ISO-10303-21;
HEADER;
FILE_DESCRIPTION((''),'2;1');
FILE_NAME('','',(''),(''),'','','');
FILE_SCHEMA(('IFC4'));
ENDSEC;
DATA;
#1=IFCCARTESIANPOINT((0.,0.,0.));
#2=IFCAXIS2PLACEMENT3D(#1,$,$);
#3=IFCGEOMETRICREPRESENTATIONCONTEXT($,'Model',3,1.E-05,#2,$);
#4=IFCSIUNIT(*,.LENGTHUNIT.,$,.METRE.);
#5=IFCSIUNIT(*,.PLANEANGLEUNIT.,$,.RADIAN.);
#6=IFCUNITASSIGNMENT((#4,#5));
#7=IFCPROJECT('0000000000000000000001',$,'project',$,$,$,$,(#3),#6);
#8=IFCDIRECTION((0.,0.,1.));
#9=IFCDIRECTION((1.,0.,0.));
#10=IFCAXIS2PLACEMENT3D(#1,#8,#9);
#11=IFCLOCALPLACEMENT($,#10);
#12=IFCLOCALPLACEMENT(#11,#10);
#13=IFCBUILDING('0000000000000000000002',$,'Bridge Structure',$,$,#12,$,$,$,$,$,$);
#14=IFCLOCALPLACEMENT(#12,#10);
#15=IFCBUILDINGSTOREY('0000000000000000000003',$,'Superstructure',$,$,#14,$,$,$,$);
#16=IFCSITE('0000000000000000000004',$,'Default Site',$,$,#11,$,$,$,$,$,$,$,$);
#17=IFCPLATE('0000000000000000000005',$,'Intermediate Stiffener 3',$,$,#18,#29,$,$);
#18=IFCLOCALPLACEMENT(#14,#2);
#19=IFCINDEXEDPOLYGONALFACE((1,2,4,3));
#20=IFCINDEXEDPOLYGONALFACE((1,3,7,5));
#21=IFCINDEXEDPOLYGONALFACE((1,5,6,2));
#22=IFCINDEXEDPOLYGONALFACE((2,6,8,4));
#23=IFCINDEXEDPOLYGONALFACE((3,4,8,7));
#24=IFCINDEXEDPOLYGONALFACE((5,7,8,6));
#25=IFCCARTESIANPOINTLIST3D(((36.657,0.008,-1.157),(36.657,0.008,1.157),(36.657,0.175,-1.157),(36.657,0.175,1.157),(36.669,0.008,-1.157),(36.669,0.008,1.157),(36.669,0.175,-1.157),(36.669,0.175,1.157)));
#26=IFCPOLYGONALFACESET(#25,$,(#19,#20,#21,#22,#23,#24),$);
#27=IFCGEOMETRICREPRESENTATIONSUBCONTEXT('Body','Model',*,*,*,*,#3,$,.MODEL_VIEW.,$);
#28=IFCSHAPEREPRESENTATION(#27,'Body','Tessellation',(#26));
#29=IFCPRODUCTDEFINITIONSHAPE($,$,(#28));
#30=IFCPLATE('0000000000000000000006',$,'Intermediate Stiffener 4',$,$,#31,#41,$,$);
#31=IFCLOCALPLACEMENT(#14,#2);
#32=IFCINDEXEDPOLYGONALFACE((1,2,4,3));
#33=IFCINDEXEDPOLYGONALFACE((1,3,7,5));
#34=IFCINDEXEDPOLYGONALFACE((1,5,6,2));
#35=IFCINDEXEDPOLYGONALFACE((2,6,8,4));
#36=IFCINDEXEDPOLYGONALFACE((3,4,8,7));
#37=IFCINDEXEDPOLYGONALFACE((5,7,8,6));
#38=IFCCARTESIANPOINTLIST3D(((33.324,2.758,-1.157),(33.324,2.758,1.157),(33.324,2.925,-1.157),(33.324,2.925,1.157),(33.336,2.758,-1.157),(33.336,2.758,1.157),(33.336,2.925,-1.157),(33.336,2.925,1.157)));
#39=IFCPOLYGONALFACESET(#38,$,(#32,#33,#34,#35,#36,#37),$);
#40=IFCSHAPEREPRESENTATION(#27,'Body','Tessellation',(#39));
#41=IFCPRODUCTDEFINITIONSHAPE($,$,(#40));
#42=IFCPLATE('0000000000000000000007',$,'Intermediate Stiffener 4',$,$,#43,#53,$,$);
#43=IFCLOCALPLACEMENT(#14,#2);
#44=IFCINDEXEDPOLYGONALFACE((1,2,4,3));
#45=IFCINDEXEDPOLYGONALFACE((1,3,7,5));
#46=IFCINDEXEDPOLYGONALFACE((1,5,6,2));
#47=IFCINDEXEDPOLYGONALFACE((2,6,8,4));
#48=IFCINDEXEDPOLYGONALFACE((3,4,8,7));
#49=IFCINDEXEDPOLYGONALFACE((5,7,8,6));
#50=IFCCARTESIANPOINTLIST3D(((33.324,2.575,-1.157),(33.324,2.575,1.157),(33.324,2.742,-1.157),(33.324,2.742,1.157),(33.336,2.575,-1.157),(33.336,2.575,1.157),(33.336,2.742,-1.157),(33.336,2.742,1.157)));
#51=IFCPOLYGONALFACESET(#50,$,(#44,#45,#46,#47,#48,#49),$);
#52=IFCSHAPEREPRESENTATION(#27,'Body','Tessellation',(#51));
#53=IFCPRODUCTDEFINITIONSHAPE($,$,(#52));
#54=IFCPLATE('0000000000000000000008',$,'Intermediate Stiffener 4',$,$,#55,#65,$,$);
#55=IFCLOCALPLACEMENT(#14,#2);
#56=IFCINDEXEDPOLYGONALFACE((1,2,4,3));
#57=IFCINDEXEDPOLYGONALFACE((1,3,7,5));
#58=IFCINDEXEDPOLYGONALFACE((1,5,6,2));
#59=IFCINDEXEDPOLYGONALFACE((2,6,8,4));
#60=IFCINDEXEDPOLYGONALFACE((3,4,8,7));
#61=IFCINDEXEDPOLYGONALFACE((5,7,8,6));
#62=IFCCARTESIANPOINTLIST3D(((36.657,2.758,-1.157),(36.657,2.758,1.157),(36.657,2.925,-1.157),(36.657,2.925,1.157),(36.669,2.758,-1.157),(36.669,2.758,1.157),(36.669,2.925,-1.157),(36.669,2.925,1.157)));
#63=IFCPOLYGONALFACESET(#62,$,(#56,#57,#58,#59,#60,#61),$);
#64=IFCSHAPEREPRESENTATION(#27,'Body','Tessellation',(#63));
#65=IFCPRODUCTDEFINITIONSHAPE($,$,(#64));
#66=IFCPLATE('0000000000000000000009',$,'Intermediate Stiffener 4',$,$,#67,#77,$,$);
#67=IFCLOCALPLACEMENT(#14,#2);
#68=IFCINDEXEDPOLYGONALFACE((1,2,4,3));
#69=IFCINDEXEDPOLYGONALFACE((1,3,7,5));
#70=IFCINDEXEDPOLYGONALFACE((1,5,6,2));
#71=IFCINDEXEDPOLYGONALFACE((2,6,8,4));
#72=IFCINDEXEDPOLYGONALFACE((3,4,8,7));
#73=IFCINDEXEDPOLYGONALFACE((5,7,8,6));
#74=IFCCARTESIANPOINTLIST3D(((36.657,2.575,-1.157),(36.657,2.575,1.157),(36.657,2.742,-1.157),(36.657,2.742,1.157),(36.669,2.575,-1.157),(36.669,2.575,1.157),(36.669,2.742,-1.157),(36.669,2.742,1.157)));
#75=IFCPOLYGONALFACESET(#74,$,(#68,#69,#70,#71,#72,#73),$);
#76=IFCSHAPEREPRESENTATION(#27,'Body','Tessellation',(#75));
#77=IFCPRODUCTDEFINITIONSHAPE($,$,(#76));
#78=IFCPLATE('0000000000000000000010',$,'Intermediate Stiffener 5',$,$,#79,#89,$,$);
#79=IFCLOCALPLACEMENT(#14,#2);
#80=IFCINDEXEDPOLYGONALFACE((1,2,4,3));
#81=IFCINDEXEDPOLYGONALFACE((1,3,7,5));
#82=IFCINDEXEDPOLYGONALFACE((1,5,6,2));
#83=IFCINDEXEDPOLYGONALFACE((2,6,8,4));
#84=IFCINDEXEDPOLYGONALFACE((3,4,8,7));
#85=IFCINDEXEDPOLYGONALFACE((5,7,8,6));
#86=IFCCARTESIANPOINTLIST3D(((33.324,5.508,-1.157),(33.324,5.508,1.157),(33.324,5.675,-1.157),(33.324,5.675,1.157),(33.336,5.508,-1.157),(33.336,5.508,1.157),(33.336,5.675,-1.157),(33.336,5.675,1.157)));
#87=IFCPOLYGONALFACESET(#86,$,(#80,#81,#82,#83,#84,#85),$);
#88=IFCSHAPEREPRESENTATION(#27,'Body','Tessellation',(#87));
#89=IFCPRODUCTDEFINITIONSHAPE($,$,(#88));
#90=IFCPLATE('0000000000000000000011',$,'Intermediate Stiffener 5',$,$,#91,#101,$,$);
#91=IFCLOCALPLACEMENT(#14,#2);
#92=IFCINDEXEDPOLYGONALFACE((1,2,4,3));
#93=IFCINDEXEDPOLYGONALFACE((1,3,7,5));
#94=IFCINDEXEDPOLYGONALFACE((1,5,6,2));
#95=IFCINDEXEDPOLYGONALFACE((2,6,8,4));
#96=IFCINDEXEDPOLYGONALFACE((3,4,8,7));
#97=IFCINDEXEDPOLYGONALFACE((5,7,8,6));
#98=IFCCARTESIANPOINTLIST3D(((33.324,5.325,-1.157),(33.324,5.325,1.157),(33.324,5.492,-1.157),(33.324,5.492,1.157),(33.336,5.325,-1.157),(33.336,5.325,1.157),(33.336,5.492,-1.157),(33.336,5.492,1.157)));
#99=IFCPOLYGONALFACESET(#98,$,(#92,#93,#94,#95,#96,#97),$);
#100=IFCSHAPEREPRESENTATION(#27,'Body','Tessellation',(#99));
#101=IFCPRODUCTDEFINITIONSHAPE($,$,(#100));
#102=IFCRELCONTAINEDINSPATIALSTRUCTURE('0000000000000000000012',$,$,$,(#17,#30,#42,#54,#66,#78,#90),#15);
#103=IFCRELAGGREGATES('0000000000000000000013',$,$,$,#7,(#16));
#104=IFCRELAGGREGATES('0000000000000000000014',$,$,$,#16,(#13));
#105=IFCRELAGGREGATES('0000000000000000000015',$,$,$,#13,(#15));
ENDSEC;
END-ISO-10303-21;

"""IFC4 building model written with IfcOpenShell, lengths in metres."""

from ifc_helpers import new_model, si_unit, frame, origin, origin_with_axes, origin_2d_with_axis, place, context, subcontext, project, spatial, rectangle, extrude, element, save


model = new_model("IFC4")

# Units and contexts
model_context = context("Model", 3, precision=1e-05, world=origin())
body_context = subcontext(model_context, "Body", "Model", "MODEL_VIEW")
ifc_project = project(units=[si_unit("LENGTHUNIT", "METRE"), si_unit("PLANEANGLEUNIT", "RADIAN")], contexts=[model_context])

# Site, building, storey
site_placement = place(None, origin_with_axes())
site = spatial("IfcSite", under=ifc_project, at=site_placement, Name="Default Site")
building_placement = place(site_placement, origin_with_axes())
building = spatial("IfcBuilding", under=site, at=building_placement, Name="Bridge Structure")
storey_placement = place(building_placement, origin_with_axes())
storey = spatial("IfcBuildingStorey", under=building, at=storey_placement, Name="Superstructure")

# Plates
for number, where, z_axis, x_axis, name in (
    (1, (36.663, 0.0915, -1.157), (0.0, 0.0, 1.0), (1.0, 0.0, 0.0), "Intermediate Stiffener 3"),
    (2, (33.33, 2.8415, -1.157), (0.0, 0.0, 1.0), (1.0, 0.0, 0.0), "Intermediate Stiffener 4"),
    (3, (33.33, 2.6585, -1.157), (0.0, 0.0, 1.0), (1.0, 0.0, 0.0), "Intermediate Stiffener 4"),
    (4, (36.663, 2.8415, -1.157), (0.0, 0.0, 1.0), (1.0, 0.0, 0.0), "Intermediate Stiffener 4"),
    (5, (36.663, 2.6585, -1.157), (0.0, 0.0, 1.0), (1.0, 0.0, 0.0), "Intermediate Stiffener 4"),
    (6, (33.33, 5.5915, -1.157), (0.0, 0.0, 1.0), (1.0, 0.0, 0.0), "Intermediate Stiffener 5"),
    (7, (33.33, 5.4085, -1.157), (0.0, 0.0, 1.0), (1.0, 0.0, 0.0), "Intermediate Stiffener 5"),
):
    element("IfcPlate", number, at=place(storey_placement, frame(where, z_axis=z_axis, x_axis=x_axis)), inside=storey, Name=name, context=body_context, shape_type="SweptSolid", body=[
        extrude(rectangle(XDim=0.012, YDim=0.167, at=origin_2d_with_axis()), origin_with_axes(), (0.0, 0.0, 1.0), 2.314),
    ])

save(model, "model.ifc")
